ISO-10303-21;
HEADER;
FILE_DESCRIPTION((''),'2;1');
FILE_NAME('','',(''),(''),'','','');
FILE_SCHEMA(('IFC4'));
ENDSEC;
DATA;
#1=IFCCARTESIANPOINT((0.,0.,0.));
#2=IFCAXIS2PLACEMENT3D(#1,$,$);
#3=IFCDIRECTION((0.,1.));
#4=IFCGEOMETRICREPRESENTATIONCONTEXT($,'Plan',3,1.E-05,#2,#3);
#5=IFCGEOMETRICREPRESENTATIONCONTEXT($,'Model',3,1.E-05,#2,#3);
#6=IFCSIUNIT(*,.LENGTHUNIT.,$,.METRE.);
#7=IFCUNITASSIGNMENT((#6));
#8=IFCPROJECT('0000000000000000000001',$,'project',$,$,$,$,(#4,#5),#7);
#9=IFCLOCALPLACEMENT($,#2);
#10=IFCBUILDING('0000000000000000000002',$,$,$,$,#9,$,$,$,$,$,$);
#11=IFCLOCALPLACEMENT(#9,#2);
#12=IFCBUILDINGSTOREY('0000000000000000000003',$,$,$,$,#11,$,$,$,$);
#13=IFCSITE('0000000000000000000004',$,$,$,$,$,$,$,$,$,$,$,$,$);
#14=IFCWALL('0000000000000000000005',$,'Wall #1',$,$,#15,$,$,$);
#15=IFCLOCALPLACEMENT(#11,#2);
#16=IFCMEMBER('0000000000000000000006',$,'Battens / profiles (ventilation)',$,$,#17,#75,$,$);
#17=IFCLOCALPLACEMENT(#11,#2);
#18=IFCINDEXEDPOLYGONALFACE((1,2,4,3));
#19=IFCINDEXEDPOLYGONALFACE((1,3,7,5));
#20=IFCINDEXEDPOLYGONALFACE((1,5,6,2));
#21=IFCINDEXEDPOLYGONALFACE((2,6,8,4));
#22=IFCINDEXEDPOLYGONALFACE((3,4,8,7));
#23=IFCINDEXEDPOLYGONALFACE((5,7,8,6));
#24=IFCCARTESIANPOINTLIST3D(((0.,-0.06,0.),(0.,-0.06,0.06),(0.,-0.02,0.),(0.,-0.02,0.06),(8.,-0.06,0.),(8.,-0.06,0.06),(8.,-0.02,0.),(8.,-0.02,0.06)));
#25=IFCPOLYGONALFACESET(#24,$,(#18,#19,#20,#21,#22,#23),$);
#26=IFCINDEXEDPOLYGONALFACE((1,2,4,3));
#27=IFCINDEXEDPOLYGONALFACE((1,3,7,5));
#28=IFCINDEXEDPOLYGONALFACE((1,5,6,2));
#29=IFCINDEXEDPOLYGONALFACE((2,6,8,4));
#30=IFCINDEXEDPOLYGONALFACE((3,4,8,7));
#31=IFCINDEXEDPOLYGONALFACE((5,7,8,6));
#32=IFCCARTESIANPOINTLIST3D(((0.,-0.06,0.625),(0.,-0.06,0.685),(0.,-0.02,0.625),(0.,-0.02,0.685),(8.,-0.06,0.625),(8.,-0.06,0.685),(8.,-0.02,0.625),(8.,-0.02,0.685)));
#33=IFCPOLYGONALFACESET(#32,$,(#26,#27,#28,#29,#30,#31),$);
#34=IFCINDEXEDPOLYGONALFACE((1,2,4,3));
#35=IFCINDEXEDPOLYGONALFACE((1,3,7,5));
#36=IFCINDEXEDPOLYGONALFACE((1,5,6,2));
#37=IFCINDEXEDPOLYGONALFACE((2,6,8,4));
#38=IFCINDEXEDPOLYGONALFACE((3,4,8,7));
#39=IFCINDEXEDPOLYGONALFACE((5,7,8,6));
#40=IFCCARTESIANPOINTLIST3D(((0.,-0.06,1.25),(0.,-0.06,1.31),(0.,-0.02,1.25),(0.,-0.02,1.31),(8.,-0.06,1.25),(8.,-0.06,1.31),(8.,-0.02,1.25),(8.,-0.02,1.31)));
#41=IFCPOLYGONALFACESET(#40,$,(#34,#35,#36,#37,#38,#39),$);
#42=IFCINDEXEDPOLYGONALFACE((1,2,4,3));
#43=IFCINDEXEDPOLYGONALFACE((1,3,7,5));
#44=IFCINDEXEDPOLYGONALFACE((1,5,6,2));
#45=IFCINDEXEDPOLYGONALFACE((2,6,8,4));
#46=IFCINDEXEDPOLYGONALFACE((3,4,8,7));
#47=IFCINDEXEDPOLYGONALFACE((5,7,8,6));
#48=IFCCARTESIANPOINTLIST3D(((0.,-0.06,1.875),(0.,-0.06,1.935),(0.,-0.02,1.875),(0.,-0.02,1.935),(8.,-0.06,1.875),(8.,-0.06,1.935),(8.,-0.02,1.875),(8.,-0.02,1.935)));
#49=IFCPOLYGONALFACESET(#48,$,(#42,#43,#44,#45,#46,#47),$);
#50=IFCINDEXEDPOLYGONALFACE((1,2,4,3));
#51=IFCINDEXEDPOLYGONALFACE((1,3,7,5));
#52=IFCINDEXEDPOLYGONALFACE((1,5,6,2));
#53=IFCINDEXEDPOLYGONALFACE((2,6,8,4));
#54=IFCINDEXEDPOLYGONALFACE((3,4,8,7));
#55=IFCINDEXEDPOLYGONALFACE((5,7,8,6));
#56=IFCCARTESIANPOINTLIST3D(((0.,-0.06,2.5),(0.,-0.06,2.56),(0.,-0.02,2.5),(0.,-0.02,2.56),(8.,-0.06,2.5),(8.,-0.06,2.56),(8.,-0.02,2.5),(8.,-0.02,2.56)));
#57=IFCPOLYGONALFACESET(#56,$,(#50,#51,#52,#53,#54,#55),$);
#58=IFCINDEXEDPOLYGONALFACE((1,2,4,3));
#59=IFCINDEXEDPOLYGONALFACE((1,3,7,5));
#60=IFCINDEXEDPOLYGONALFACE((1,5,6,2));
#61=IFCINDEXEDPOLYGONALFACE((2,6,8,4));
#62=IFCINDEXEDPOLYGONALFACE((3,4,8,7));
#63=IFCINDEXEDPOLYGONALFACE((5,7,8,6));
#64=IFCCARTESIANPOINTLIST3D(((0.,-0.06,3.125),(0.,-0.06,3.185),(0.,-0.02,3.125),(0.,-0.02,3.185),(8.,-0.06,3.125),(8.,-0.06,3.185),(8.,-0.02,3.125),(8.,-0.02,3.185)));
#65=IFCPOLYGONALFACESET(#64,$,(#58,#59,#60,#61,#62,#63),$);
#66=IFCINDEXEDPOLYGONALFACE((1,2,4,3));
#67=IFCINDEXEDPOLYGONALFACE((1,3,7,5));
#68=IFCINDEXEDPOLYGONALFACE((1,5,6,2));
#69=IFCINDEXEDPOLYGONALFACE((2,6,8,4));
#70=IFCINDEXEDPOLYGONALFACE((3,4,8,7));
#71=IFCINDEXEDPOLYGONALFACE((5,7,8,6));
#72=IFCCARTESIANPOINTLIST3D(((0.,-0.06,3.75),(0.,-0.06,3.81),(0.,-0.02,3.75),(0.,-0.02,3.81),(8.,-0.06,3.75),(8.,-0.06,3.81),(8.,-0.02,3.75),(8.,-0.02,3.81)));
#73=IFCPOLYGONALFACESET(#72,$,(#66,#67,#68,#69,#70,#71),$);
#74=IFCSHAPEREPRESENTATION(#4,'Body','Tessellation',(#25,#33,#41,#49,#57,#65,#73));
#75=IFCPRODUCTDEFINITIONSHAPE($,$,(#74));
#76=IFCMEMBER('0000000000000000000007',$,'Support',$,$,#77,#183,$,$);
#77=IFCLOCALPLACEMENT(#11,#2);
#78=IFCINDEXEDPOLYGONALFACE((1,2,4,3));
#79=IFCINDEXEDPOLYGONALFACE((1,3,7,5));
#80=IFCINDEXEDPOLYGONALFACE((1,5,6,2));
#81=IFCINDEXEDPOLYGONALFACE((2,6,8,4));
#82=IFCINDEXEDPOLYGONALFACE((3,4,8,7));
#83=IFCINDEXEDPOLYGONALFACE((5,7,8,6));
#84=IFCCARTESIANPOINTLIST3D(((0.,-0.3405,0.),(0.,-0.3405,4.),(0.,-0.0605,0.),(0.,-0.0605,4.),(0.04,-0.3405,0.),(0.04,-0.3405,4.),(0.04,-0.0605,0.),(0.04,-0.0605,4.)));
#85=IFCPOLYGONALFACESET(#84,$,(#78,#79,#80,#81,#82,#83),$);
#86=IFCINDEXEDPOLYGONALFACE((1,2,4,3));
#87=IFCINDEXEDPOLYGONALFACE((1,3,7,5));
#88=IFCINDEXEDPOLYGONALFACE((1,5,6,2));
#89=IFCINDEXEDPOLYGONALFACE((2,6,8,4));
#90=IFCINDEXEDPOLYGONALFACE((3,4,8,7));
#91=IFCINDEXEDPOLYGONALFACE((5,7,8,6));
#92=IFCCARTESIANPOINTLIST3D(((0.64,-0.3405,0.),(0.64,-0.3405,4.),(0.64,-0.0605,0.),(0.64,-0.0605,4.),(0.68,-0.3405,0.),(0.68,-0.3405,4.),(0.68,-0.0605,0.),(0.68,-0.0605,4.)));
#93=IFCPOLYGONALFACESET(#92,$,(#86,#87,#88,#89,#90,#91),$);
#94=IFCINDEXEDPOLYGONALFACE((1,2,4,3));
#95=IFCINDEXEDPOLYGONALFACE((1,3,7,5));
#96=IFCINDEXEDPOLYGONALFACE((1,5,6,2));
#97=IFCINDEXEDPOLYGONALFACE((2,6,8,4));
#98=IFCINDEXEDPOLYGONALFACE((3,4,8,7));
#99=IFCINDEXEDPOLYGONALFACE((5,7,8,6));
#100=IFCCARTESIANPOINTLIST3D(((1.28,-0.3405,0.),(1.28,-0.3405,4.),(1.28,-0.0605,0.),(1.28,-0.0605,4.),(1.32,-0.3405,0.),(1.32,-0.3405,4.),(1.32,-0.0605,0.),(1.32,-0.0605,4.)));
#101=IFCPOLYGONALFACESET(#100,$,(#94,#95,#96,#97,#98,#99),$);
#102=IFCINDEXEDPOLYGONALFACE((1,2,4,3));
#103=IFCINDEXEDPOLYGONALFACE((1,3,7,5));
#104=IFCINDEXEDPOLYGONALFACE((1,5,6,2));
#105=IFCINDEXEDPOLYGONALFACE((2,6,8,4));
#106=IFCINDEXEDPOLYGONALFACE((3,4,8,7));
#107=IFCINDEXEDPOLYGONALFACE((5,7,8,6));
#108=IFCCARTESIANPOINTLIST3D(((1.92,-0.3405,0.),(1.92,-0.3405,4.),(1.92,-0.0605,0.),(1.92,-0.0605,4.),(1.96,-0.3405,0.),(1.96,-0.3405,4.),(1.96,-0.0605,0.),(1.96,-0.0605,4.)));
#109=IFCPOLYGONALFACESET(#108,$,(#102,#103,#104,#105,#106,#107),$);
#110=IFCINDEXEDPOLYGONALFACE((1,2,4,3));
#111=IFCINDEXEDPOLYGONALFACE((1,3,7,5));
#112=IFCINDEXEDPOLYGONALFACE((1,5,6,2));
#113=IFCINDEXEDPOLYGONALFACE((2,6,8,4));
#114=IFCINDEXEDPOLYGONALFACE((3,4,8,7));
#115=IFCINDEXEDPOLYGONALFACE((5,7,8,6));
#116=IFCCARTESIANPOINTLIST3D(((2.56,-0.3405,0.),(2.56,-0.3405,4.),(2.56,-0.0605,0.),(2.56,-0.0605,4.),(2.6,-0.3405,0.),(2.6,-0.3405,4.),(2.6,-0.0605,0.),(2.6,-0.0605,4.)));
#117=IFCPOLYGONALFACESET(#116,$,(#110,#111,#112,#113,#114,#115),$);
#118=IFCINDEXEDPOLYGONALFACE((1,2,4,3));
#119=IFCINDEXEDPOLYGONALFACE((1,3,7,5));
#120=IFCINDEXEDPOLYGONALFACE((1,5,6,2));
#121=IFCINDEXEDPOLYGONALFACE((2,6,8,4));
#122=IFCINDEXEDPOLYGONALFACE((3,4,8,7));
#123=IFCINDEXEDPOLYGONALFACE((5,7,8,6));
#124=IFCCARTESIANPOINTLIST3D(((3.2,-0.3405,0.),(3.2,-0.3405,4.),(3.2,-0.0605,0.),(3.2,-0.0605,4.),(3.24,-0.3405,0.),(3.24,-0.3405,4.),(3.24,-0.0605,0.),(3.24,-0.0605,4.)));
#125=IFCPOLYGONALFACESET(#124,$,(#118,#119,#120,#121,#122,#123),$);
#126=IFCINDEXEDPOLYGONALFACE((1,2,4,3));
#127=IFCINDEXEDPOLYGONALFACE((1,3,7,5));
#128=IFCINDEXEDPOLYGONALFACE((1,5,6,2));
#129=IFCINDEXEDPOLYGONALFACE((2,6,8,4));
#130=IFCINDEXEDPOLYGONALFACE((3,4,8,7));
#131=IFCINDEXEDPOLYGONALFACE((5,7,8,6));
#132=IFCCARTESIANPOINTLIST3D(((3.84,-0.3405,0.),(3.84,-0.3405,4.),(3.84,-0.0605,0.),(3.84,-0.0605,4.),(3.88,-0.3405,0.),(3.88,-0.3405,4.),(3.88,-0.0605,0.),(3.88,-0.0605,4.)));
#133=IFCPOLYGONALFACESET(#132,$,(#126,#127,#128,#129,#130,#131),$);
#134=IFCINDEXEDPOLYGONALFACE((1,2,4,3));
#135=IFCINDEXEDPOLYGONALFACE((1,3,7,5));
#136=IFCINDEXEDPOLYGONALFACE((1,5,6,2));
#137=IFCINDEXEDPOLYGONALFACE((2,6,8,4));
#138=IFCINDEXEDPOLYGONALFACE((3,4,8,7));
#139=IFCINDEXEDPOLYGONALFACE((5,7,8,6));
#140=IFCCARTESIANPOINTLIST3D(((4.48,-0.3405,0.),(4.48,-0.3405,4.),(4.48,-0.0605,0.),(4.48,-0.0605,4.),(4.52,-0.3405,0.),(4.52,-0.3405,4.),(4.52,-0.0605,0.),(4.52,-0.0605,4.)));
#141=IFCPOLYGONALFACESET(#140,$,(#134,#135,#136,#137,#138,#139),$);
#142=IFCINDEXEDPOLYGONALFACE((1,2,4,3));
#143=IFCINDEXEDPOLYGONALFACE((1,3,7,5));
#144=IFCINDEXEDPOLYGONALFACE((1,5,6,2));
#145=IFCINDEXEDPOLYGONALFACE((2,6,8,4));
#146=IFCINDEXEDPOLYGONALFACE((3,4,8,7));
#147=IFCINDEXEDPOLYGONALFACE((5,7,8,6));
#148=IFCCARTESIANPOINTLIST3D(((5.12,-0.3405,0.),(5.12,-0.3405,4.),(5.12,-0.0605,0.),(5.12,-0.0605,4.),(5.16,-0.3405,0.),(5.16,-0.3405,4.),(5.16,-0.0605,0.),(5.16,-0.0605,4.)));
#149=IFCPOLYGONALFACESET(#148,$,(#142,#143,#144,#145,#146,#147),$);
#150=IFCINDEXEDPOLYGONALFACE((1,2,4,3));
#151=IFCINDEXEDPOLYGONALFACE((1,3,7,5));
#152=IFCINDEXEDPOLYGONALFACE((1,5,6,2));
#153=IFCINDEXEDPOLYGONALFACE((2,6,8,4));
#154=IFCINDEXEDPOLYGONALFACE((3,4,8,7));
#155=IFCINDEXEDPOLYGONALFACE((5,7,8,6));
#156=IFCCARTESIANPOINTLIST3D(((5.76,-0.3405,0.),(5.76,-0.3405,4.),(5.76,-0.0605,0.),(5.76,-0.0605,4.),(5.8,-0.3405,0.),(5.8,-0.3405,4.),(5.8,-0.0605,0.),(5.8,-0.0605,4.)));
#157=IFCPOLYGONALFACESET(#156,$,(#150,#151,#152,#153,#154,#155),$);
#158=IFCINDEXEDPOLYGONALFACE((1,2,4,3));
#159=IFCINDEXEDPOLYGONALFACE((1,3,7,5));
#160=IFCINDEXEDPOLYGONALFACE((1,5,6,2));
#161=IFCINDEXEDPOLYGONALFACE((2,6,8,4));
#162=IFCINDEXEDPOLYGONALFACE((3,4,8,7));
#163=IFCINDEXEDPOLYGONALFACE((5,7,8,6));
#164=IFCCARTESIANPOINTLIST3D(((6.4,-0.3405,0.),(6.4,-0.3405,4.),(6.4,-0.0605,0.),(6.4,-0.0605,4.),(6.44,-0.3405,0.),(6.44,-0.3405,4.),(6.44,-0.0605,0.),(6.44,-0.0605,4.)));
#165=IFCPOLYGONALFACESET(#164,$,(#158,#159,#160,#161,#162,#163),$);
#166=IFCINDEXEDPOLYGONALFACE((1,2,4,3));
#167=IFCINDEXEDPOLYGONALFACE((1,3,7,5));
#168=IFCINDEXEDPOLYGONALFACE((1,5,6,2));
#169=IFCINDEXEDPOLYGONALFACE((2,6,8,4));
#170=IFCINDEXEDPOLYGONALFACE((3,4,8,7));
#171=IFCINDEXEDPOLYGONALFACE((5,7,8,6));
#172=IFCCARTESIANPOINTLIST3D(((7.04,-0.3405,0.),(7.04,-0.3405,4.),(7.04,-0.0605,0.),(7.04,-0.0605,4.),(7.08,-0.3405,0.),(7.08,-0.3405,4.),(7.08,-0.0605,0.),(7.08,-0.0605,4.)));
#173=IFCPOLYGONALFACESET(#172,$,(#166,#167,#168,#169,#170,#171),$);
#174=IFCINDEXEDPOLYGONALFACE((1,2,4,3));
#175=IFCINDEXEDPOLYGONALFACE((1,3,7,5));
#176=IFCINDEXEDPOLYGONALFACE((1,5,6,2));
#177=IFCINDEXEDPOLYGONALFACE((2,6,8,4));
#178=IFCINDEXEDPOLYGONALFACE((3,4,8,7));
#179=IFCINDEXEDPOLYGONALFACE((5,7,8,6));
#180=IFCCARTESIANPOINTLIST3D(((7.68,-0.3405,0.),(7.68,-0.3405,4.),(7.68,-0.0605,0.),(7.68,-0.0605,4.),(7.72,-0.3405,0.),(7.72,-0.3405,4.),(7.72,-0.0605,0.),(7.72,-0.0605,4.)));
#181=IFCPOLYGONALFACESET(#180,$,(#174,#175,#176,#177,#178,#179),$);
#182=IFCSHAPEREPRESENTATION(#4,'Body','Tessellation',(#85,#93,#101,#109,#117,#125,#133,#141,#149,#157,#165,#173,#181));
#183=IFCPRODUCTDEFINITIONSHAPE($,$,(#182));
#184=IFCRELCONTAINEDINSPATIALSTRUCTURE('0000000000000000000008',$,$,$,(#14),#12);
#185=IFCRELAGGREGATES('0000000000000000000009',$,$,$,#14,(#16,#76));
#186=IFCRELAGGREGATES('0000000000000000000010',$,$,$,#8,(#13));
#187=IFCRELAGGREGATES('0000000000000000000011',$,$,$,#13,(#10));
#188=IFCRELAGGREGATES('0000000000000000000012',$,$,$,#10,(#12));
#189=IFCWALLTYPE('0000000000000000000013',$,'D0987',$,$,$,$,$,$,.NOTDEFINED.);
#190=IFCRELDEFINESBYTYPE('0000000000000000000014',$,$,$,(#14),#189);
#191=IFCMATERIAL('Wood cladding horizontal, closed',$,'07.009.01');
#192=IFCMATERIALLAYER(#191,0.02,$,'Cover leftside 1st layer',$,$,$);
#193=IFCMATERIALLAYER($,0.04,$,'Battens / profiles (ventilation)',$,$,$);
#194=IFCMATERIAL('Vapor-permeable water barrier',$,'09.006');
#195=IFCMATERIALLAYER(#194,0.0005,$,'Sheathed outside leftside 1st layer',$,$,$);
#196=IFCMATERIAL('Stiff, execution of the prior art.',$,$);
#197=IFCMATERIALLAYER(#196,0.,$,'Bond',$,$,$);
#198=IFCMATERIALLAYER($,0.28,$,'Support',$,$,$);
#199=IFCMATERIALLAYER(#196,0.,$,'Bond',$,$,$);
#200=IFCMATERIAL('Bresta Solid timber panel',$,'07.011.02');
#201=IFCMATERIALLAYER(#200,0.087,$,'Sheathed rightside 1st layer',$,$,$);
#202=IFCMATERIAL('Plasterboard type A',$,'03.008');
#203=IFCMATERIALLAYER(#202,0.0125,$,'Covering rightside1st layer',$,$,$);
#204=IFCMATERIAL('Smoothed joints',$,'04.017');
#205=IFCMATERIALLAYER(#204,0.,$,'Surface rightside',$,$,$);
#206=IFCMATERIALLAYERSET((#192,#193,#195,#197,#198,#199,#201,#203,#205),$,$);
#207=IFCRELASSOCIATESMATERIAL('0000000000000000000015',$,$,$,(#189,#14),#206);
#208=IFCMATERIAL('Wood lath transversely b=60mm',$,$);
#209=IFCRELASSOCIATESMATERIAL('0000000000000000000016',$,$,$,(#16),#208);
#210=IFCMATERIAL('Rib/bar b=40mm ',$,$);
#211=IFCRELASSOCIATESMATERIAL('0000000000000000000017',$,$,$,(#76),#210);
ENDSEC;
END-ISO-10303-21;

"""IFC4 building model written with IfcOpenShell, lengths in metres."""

from ifc_helpers import new_model, si_unit, direction, frame, frame_2d, origin, place, context, project, spatial, rectangle, extrude, material, layer, layer_set, type_object, element, aggregate, save


model = new_model("IFC4")

# Units and contexts
plan_context = context("Plan", 3, precision=1e-05, world=origin(), true_north=direction((0.0, 1.0)))
model_context = context("Model", 3, precision=1e-05, world=origin(), true_north=direction((0.0, 1.0)))
ifc_project = project(units=[si_unit("LENGTHUNIT", "METRE")], contexts=[plan_context, model_context])

# Site, building, storey
site = spatial("IfcSite", under=ifc_project)
building_placement = place(None, origin())
building = spatial("IfcBuilding", under=site, at=building_placement)
storey_placement = place(building_placement, origin())
storey = spatial("IfcBuildingStorey", under=building, at=storey_placement)

# Wall, members
ifc_material_1 = material(Name="Wood cladding horizontal, closed", Category="07.009.01")
ifc_layer_1 = layer(ifc_material_1, 0.02, Name="Cover leftside 1st layer")
ifc_layer_2 = layer(None, 0.04, Name="Battens / profiles (ventilation)")
ifc_material_2 = material(Name="Vapor-permeable water barrier", Category="09.006")
ifc_layer_3 = layer(ifc_material_2, 0.0005, Name="Sheathed outside leftside 1st layer")
ifc_material_3 = material(Name="Stiff, execution of the prior art.")
ifc_layer_4 = layer(ifc_material_3, 0.0, Name="Bond")
ifc_layer_5 = layer(None, 0.28, Name="Support")
ifc_layer_6 = layer(ifc_material_3, 0.0, Name="Bond")
ifc_material_4 = material(Name="Bresta Solid timber panel", Category="07.011.02")
ifc_layer_7 = layer(ifc_material_4, 0.087, Name="Sheathed rightside 1st layer")
ifc_material_5 = material(Name="Plasterboard type A", Category="03.008")
ifc_layer_8 = layer(ifc_material_5, 0.0125, Name="Covering rightside1st layer")
ifc_material_6 = material(Name="Smoothed joints", Category="04.017")
ifc_layer_9 = layer(ifc_material_6, 0.0, Name="Surface rightside")
ifc_layer_set = layer_set([ifc_layer_1, ifc_layer_2, ifc_layer_3, ifc_layer_4, ifc_layer_5, ifc_layer_6, ifc_layer_7, ifc_layer_8, ifc_layer_9])
wall_type = type_object("IfcWallType", Name="D0987", PredefinedType="NOTDEFINED", material=ifc_layer_set)
wall_placement = place(None, frame((0.0, 0.0, 0.0), z_axis=(0.0, -1.0, 0.0), x_axis=(1.0, 0.0, 0.0)))
wall = element("IfcWall", 1, at=wall_placement, inside=storey, type_object=wall_type, material=ifc_layer_set, Name="Wall #1")
ifc_material_7 = material(Name="Wood lath transversely b=60mm")
member_1_placement = place(wall_placement, origin())
member_1 = element("IfcMember", 2, at=member_1_placement, material=ifc_material_7, Name="Battens / profiles (ventilation)", context=plan_context, shape_type="SweptSolid", body=[
    extrude(rectangle(XDim=0.06, YDim=0.04, at=frame_2d((0.03, 0.02), x_axis=(1.0, 0.0))), frame((0.0, 0.0, 0.02), z_axis=(1.0, 0.0, 0.0), x_axis=(0.0, 1.0, 0.0)), (0.0, 0.0, 1.0), 8.0),
    extrude(rectangle(XDim=0.06, YDim=0.04, at=frame_2d((0.03, 0.02), x_axis=(1.0, 0.0))), frame((0.0, 0.625, 0.02), z_axis=(1.0, 0.0, 0.0), x_axis=(0.0, 1.0, 0.0)), (0.0, 0.0, 1.0), 8.0),
    extrude(rectangle(XDim=0.06, YDim=0.04, at=frame_2d((0.03, 0.02), x_axis=(1.0, 0.0))), frame((0.0, 1.25, 0.02), z_axis=(1.0, 0.0, 0.0), x_axis=(0.0, 1.0, 0.0)), (0.0, 0.0, 1.0), 8.0),
    extrude(rectangle(XDim=0.06, YDim=0.04, at=frame_2d((0.03, 0.02), x_axis=(1.0, 0.0))), frame((0.0, 1.875, 0.02), z_axis=(1.0, 0.0, 0.0), x_axis=(0.0, 1.0, 0.0)), (0.0, 0.0, 1.0), 8.0),
    extrude(rectangle(XDim=0.06, YDim=0.04, at=frame_2d((0.03, 0.02), x_axis=(1.0, 0.0))), frame((0.0, 2.5, 0.02), z_axis=(1.0, 0.0, 0.0), x_axis=(0.0, 1.0, 0.0)), (0.0, 0.0, 1.0), 8.0),
    extrude(rectangle(XDim=0.06, YDim=0.04, at=frame_2d((0.03, 0.02), x_axis=(1.0, 0.0))), frame((0.0, 3.125, 0.02), z_axis=(1.0, 0.0, 0.0), x_axis=(0.0, 1.0, 0.0)), (0.0, 0.0, 1.0), 8.0),
    extrude(rectangle(XDim=0.06, YDim=0.04, at=frame_2d((0.03, 0.02), x_axis=(1.0, 0.0))), frame((0.0, 3.75, 0.02), z_axis=(1.0, 0.0, 0.0), x_axis=(0.0, 1.0, 0.0)), (0.0, 0.0, 1.0), 8.0),
])
ifc_material_8 = material(Name="Rib/bar b=40mm ")
member_2_placement = place(wall_placement, origin())
member_2 = element("IfcMember", 3, at=member_2_placement, material=ifc_material_8, Name="Support", context=plan_context, shape_type="SweptSolid", body=[
    extrude(rectangle(XDim=0.04, YDim=0.28, at=frame_2d((0.02, 0.14), x_axis=(1.0, 0.0))), frame((0.0, 4.0, 0.0605), z_axis=(0.0, -1.0, 0.0), x_axis=(1.0, 0.0, 0.0)), (0.0, 0.0, 1.0), 4.0),
    extrude(rectangle(XDim=0.04, YDim=0.28, at=frame_2d((0.02, 0.14), x_axis=(1.0, 0.0))), frame((0.64, 4.0, 0.0605), z_axis=(0.0, -1.0, 0.0), x_axis=(1.0, 0.0, 0.0)), (0.0, 0.0, 1.0), 4.0),
    extrude(rectangle(XDim=0.04, YDim=0.28, at=frame_2d((0.02, 0.14), x_axis=(1.0, 0.0))), frame((1.28, 4.0, 0.0605), z_axis=(0.0, -1.0, 0.0), x_axis=(1.0, 0.0, 0.0)), (0.0, 0.0, 1.0), 4.0),
    extrude(rectangle(XDim=0.04, YDim=0.28, at=frame_2d((0.02, 0.14), x_axis=(1.0, 0.0))), frame((1.92, 4.0, 0.0605), z_axis=(0.0, -1.0, 0.0), x_axis=(1.0, 0.0, 0.0)), (0.0, 0.0, 1.0), 4.0),
    extrude(rectangle(XDim=0.04, YDim=0.28, at=frame_2d((0.02, 0.14), x_axis=(1.0, 0.0))), frame((2.56, 4.0, 0.0605), z_axis=(0.0, -1.0, 0.0), x_axis=(1.0, 0.0, 0.0)), (0.0, 0.0, 1.0), 4.0),
    extrude(rectangle(XDim=0.04, YDim=0.28, at=frame_2d((0.02, 0.14), x_axis=(1.0, 0.0))), frame((3.2, 4.0, 0.0605), z_axis=(0.0, -1.0, 0.0), x_axis=(1.0, 0.0, 0.0)), (0.0, 0.0, 1.0), 4.0),
    extrude(rectangle(XDim=0.04, YDim=0.28, at=frame_2d((0.02, 0.14), x_axis=(1.0, 0.0))), frame((3.84, 4.0, 0.0605), z_axis=(0.0, -1.0, 0.0), x_axis=(1.0, 0.0, 0.0)), (0.0, 0.0, 1.0), 4.0),
    extrude(rectangle(XDim=0.04, YDim=0.28, at=frame_2d((0.02, 0.14), x_axis=(1.0, 0.0))), frame((4.48, 4.0, 0.0605), z_axis=(0.0, -1.0, 0.0), x_axis=(1.0, 0.0, 0.0)), (0.0, 0.0, 1.0), 4.0),
    extrude(rectangle(XDim=0.04, YDim=0.28, at=frame_2d((0.02, 0.14), x_axis=(1.0, 0.0))), frame((5.12, 4.0, 0.0605), z_axis=(0.0, -1.0, 0.0), x_axis=(1.0, 0.0, 0.0)), (0.0, 0.0, 1.0), 4.0),
    extrude(rectangle(XDim=0.04, YDim=0.28, at=frame_2d((0.02, 0.14), x_axis=(1.0, 0.0))), frame((5.76, 4.0, 0.0605), z_axis=(0.0, -1.0, 0.0), x_axis=(1.0, 0.0, 0.0)), (0.0, 0.0, 1.0), 4.0),
    extrude(rectangle(XDim=0.04, YDim=0.28, at=frame_2d((0.02, 0.14), x_axis=(1.0, 0.0))), frame((6.4, 4.0, 0.0605), z_axis=(0.0, -1.0, 0.0), x_axis=(1.0, 0.0, 0.0)), (0.0, 0.0, 1.0), 4.0),
    extrude(rectangle(XDim=0.04, YDim=0.28, at=frame_2d((0.02, 0.14), x_axis=(1.0, 0.0))), frame((7.04, 4.0, 0.0605), z_axis=(0.0, -1.0, 0.0), x_axis=(1.0, 0.0, 0.0)), (0.0, 0.0, 1.0), 4.0),
    extrude(rectangle(XDim=0.04, YDim=0.28, at=frame_2d((0.02, 0.14), x_axis=(1.0, 0.0))), frame((7.68, 4.0, 0.0605), z_axis=(0.0, -1.0, 0.0), x_axis=(1.0, 0.0, 0.0)), (0.0, 0.0, 1.0), 4.0),
])
aggregate(wall, [member_1, member_2])

save(model, "model.ifc")
